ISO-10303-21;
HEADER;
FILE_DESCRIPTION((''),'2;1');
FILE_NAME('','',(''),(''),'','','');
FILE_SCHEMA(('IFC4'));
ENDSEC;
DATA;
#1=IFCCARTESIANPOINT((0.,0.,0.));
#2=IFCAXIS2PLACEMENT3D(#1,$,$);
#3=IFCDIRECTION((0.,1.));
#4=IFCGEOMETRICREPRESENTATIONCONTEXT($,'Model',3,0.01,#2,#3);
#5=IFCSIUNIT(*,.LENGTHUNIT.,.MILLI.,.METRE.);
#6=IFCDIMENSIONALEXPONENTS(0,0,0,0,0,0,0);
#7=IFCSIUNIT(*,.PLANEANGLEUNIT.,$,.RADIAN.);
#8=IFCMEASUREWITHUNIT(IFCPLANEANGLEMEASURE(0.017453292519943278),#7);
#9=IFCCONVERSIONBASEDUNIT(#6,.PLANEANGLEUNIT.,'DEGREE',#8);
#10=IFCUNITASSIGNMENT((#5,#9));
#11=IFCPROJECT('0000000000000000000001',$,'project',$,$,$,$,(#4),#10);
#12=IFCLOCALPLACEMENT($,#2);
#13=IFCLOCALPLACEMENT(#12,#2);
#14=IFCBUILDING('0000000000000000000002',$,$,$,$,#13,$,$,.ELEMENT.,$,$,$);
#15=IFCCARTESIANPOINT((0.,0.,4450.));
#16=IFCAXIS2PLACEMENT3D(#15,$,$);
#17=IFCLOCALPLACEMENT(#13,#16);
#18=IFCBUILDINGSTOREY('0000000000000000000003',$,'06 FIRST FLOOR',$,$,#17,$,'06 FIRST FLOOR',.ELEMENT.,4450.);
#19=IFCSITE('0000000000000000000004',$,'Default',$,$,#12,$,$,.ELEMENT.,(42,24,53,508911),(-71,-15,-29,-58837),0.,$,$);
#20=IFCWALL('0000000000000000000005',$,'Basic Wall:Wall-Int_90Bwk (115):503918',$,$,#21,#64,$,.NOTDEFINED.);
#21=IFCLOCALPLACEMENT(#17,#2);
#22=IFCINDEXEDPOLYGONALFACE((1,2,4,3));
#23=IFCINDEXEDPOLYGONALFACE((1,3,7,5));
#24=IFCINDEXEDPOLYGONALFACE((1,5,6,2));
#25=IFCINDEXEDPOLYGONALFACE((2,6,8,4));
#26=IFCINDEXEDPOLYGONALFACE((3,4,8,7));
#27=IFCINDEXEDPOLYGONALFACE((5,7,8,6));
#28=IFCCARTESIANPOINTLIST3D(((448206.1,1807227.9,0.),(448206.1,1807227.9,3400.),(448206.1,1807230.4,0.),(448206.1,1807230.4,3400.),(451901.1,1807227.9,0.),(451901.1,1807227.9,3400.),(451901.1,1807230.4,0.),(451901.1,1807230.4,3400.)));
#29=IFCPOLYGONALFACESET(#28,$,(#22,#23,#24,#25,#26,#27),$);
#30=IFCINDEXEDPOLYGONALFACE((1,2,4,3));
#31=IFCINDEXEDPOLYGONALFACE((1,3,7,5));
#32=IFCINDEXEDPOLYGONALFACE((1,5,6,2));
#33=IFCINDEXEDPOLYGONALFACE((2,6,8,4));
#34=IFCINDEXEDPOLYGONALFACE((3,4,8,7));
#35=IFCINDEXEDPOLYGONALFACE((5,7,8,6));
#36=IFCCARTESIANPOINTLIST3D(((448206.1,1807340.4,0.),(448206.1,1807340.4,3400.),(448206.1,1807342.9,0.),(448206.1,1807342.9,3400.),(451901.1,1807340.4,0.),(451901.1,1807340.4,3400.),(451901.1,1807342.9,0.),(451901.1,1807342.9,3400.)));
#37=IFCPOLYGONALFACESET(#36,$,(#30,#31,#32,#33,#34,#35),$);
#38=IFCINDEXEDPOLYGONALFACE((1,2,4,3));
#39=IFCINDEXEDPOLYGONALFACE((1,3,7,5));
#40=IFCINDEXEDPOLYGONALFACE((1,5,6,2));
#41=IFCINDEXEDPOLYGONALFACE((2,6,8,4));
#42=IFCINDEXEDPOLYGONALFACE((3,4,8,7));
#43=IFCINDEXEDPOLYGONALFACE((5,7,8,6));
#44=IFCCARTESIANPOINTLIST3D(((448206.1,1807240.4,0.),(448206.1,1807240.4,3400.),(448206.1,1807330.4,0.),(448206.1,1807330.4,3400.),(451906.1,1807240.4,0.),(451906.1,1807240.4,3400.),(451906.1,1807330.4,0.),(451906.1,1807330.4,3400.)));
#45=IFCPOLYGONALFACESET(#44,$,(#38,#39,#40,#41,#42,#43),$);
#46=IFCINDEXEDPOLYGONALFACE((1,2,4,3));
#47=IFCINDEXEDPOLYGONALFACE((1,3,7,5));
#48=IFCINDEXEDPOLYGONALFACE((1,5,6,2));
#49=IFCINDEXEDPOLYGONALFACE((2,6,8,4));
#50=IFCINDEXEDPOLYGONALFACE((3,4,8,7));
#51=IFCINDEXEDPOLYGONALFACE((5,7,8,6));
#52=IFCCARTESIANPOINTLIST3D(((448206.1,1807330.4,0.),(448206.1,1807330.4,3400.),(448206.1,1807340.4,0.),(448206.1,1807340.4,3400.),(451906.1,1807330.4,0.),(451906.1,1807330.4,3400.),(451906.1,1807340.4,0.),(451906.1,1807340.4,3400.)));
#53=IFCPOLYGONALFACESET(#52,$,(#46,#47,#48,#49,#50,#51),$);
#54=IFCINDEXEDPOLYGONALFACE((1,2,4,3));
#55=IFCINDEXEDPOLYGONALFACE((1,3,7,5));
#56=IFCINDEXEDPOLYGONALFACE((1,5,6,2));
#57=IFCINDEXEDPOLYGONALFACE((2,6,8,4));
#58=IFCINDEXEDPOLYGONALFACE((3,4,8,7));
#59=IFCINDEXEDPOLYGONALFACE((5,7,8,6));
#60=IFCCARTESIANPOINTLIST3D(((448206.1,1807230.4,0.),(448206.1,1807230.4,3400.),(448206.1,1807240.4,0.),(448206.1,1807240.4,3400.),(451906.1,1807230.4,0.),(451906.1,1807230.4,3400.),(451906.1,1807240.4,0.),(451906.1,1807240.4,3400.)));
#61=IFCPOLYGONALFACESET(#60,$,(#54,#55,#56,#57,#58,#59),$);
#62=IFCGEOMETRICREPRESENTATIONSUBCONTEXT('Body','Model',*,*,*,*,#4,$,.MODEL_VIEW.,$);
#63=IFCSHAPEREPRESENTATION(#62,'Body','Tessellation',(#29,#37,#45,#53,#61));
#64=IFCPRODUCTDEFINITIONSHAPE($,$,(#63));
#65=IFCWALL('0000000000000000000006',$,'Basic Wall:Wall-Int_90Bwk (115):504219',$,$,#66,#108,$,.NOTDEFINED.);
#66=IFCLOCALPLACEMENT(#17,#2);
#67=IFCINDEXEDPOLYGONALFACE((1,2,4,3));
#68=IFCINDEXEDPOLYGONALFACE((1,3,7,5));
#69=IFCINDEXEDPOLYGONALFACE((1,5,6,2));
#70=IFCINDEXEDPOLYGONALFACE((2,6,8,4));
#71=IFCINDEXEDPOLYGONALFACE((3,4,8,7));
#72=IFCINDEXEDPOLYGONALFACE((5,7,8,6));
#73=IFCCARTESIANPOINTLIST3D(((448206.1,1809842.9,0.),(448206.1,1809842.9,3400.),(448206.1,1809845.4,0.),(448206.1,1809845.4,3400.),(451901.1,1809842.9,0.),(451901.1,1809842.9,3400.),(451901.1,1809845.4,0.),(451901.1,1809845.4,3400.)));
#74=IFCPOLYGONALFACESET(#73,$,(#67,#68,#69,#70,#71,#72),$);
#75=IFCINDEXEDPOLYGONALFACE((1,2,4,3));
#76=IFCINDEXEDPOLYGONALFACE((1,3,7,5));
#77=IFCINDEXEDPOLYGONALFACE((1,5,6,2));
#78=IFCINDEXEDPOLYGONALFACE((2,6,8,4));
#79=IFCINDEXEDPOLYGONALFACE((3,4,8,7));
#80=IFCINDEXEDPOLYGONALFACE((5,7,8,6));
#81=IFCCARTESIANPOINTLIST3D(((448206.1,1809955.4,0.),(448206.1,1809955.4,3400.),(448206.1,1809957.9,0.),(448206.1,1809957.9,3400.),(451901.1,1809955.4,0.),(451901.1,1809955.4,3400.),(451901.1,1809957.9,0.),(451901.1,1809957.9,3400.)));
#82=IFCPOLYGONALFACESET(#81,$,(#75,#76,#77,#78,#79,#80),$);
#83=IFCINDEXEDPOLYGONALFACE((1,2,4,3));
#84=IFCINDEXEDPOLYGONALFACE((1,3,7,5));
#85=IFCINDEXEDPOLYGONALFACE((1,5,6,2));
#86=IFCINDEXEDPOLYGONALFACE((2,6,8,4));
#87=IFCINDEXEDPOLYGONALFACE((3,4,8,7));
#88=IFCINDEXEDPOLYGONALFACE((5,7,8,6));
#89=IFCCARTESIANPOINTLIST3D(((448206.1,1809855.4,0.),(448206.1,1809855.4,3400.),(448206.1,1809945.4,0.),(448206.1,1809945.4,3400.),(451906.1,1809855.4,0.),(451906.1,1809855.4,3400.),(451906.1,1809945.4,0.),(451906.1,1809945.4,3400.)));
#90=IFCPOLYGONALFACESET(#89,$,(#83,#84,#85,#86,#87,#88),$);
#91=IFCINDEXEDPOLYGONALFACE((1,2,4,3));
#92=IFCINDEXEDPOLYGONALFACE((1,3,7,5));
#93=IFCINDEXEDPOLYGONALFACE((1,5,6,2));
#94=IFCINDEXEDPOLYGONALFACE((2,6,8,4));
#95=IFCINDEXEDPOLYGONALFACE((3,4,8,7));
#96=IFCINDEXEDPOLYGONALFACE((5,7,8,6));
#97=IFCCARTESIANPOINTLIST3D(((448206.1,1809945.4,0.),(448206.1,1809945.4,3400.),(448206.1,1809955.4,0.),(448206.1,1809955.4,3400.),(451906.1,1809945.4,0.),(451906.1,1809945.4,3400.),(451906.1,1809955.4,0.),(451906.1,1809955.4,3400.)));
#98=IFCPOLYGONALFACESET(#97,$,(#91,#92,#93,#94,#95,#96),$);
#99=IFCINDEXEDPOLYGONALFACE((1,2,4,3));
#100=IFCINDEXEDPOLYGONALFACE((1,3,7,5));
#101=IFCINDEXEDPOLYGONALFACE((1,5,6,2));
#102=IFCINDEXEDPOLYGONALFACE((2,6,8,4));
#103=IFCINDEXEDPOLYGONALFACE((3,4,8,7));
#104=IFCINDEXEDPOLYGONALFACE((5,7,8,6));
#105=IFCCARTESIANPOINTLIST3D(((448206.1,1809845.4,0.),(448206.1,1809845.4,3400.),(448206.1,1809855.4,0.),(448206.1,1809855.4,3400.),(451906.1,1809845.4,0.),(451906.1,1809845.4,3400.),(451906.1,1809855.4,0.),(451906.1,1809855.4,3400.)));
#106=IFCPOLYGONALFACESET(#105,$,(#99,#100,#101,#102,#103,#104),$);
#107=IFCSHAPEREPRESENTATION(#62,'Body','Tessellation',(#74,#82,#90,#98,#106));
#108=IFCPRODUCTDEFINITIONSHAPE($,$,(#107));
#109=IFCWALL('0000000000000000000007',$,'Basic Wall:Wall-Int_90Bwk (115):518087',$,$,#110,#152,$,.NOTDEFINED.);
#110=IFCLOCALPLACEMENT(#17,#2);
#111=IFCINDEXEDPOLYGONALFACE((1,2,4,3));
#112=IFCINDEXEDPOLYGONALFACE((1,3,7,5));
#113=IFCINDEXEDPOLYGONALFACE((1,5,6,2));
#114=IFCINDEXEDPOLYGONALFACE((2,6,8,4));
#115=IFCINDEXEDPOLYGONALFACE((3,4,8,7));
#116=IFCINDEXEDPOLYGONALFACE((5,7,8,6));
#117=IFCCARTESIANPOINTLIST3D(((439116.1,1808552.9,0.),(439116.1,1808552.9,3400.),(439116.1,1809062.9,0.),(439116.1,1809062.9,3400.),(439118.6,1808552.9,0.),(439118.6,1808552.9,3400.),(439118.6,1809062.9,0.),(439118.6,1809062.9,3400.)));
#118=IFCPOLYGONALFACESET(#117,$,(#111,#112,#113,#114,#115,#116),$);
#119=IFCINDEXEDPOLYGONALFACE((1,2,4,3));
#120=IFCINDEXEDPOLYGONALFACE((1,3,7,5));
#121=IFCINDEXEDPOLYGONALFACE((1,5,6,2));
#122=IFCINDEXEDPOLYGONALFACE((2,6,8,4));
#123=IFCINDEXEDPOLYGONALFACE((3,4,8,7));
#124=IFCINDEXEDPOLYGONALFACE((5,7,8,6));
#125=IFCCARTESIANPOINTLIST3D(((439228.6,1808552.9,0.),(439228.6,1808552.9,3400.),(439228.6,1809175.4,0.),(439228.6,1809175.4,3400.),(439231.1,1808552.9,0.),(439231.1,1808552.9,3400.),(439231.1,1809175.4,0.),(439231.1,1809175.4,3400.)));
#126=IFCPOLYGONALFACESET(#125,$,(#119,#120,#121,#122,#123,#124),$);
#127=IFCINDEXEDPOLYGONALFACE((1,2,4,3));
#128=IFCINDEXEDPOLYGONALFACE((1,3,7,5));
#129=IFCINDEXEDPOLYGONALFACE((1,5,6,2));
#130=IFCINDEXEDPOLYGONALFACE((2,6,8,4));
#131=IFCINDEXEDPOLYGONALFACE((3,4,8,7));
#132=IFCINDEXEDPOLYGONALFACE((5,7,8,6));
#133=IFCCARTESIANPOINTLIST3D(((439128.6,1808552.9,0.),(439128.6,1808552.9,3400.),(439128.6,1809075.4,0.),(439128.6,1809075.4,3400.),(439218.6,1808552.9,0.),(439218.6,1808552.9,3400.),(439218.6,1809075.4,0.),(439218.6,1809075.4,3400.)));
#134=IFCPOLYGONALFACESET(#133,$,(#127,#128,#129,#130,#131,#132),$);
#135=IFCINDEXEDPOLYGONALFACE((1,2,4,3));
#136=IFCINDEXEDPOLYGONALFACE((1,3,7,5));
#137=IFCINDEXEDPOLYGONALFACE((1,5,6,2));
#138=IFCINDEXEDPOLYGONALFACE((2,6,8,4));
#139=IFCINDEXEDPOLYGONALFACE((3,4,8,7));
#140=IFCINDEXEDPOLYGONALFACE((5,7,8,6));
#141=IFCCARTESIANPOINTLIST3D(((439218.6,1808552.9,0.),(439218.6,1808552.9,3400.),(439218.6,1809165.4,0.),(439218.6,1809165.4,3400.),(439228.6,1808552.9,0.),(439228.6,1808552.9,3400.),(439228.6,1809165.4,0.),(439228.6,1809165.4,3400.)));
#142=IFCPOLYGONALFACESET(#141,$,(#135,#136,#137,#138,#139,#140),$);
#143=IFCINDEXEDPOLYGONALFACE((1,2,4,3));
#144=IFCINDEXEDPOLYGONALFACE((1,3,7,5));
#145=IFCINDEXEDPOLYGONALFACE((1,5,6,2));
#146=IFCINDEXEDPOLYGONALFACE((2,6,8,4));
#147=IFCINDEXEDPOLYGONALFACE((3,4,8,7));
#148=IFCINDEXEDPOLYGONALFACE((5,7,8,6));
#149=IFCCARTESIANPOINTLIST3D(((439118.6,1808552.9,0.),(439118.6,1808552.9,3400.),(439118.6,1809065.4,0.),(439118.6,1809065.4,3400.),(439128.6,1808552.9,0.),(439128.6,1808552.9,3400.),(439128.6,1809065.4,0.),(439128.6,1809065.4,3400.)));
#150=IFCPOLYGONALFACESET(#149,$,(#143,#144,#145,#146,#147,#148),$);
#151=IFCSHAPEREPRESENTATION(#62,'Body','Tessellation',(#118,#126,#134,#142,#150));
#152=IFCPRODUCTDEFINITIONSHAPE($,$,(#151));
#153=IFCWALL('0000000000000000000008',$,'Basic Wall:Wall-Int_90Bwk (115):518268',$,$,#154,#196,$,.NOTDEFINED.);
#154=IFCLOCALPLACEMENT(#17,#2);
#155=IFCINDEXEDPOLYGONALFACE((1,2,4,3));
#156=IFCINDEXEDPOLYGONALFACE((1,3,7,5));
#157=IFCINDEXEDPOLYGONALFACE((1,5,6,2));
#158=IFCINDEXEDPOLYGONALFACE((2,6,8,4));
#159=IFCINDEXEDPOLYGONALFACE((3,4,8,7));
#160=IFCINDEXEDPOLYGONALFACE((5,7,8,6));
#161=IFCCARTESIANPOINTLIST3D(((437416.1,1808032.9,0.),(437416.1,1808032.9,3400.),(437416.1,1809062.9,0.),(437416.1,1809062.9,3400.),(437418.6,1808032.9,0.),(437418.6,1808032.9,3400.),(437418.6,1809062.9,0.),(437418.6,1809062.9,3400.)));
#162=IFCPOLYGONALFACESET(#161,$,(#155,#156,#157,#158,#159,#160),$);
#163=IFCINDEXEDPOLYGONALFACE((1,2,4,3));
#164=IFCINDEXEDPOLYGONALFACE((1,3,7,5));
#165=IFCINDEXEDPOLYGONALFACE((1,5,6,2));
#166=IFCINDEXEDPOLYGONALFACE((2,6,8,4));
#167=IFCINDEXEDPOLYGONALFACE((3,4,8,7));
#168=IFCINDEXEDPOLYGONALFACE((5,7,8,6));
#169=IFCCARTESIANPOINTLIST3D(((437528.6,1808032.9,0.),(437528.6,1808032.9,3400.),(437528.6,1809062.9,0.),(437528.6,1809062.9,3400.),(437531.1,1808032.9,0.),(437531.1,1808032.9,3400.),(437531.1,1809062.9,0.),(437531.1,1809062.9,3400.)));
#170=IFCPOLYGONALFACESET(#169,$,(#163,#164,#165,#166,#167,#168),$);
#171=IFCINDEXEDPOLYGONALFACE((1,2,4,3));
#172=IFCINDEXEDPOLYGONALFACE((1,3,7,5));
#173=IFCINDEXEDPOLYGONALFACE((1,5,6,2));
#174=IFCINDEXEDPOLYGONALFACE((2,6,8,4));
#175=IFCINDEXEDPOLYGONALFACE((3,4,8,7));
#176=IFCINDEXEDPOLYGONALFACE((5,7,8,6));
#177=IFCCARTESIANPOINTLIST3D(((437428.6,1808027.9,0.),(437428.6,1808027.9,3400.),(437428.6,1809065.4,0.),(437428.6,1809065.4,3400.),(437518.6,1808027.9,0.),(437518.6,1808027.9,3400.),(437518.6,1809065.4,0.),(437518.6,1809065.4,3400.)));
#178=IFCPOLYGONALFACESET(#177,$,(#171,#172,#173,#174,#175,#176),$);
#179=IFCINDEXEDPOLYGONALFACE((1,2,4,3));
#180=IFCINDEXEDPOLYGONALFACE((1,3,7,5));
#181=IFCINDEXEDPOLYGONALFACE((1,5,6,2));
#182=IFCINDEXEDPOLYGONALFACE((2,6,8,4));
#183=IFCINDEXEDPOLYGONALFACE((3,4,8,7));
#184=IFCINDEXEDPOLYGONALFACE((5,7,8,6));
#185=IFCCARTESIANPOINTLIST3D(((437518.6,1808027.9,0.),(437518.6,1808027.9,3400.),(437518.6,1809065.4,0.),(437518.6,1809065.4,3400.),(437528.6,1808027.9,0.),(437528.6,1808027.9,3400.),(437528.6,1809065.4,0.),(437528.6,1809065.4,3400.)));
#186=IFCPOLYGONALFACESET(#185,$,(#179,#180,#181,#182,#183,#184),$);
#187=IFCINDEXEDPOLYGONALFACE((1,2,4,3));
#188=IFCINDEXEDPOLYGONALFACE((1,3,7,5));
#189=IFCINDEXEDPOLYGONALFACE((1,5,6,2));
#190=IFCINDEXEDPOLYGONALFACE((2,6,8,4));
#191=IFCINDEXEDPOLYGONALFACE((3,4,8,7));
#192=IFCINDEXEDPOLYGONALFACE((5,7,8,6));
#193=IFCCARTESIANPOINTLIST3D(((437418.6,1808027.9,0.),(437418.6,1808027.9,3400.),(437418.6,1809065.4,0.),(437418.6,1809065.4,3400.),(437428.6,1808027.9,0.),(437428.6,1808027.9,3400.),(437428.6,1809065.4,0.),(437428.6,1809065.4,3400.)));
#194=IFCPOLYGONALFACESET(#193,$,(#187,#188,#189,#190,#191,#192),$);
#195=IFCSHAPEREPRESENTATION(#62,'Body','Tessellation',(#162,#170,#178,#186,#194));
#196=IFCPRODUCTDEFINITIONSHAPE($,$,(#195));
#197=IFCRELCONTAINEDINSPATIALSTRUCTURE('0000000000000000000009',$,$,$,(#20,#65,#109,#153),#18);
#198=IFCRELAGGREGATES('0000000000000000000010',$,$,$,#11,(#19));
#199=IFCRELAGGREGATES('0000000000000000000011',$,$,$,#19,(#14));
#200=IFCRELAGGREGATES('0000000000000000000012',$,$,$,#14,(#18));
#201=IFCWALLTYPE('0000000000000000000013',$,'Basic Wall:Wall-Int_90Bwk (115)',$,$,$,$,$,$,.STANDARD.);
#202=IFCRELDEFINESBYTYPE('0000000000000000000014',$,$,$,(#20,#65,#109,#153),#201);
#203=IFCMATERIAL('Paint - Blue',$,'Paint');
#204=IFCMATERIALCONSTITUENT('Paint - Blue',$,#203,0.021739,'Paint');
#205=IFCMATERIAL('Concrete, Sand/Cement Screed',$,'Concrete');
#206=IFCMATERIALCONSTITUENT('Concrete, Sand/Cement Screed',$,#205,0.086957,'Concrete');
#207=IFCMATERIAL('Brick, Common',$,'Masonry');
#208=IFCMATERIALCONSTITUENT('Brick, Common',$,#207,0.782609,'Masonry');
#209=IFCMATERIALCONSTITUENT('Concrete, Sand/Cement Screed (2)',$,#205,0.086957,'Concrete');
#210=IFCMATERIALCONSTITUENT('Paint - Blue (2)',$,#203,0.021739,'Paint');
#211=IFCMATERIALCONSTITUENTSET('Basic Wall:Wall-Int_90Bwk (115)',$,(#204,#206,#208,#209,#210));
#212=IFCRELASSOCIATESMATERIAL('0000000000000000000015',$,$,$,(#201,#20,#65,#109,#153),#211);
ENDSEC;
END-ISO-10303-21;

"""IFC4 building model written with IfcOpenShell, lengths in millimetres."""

from ifc_helpers import new_model, entity, si_unit, converted_unit, direction, frame, origin, place, context, subcontext, project, spatial, indexed_curve, outline, extrude, material, constituent, constituent_set, type_object, element, save


model = new_model("IFC4")

# Units and contexts
model_context = context("Model", 3, precision=0.01, world=origin(), true_north=direction((0.0, 1.0)))
body_context = subcontext(model_context, "Body", "Model", "MODEL_VIEW")
ifc_project = project(units=[si_unit("LENGTHUNIT", "METRE", prefix="MILLI"), converted_unit("PLANEANGLEUNIT", "DEGREE", entity("IfcPlaneAngleMeasure", 0.017453292519943278), si_unit("PLANEANGLEUNIT", "RADIAN"), dimensions=[0, 0, 0, 0, 0, 0, 0])], contexts=[model_context])

# Site, building, storey
site_placement = place(None, origin())
site = spatial("IfcSite", under=ifc_project, at=site_placement, Name="Default", CompositionType="ELEMENT", RefLatitude=(42, 24, 53, 508911), RefLongitude=(-71, -15, -29, -58837), RefElevation=0.0)
building_placement = place(site_placement, origin())
building = spatial("IfcBuilding", under=site, at=building_placement, CompositionType="ELEMENT")
storey_placement = place(building_placement, frame((0.0, 0.0, 4450.0)))
storey = spatial("IfcBuildingStorey", under=building, at=storey_placement, Name="06 FIRST FLOOR", LongName="06 FIRST FLOOR", CompositionType="ELEMENT", Elevation=4450.0)

# Walls
ifc_material_1 = material(Name="Paint - Blue", Category="Paint")
ifc_constituent_1 = constituent(ifc_material_1, Name="Paint - Blue", Category="Paint", fraction=0.021739)
ifc_material_2 = material(Name="Concrete, Sand/Cement Screed", Category="Concrete")
ifc_constituent_2 = constituent(ifc_material_2, Name="Concrete, Sand/Cement Screed", Category="Concrete", fraction=0.086957)
ifc_material_3 = material(Name="Brick, Common", Category="Masonry")
ifc_constituent_3 = constituent(ifc_material_3, Name="Brick, Common", Category="Masonry", fraction=0.782609)
ifc_constituent_4 = constituent(ifc_material_2, Name="Concrete, Sand/Cement Screed (2)", Category="Concrete", fraction=0.086957)
ifc_constituent_5 = constituent(ifc_material_1, Name="Paint - Blue (2)", Category="Paint", fraction=0.021739)
ifc_constituent_set_1 = constituent_set(constituents=[ifc_constituent_1, ifc_constituent_2, ifc_constituent_3, ifc_constituent_4, ifc_constituent_5], Name="Basic Wall:Wall-Int_90Bwk (115)")
wall_type = type_object("IfcWallType", Name="Basic Wall:Wall-Int_90Bwk (115)", PredefinedType="STANDARD", material=ifc_constituent_set_1)
wall_1_placement = place(storey_placement, frame((448206.1, 1807285.4, 0.0)))
element("IfcWall", 1, at=wall_1_placement, inside=storey, type_object=wall_type, material=ifc_constituent_set_1, Name="Basic Wall:Wall-Int_90Bwk (115):503918", PredefinedType="NOTDEFINED", context=body_context, shape_type="SweptSolid", body=[
    extrude(outline(indexed_curve([(-1.2, -1847.5), (1.3, -1847.5), (1.3, 1847.5), (-1.2, 1847.5), (-1.2, -1847.5)], self_intersect=False)), frame((1847.5, -56.3, 0.0), z_axis=(0.0, 0.0, 1.0), x_axis=(0.0, 1.0, 0.0)), (0.0, 0.0, 1.0), 3400.0),
    extrude(outline(indexed_curve([(-1.2, -1847.5), (1.3, -1847.5), (1.3, 1847.5), (-1.2, 1847.5), (-1.2, -1847.5)], self_intersect=False)), frame((1847.5, 56.3, 0.0), z_axis=(0.0, 0.0, 1.0), x_axis=(0.0, -1.0, 0.0)), (0.0, 0.0, 1.0), 3400.0),
    extrude(outline(indexed_curve([(-1850.0, -45.0), (1850.0, -45.0), (1850.0, 45.0), (-1850.0, 45.0), (-1850.0, -45.0)], self_intersect=False)), frame((1850.0, 0.0, 0.0)), (0.0, 0.0, 1.0), 3400.0),
    extrude(outline(indexed_curve([(-1850.0, -5.0), (1850.0, -5.0), (1850.0, 5.0), (-1850.0, 5.0), (-1850.0, -5.0)], self_intersect=False)), frame((1850.0, 50.0, 0.0)), (0.0, 0.0, 1.0), 3400.0),
    extrude(outline(indexed_curve([(-1850.0, -5.0), (1850.0, -5.0), (1850.0, 5.0), (-1850.0, 5.0), (-1850.0, -5.0)], self_intersect=False)), frame((1850.0, -50.0, 0.0)), (0.0, 0.0, 1.0), 3400.0),
])
wall_2_placement = place(storey_placement, frame((448206.1, 1809900.4, 0.0)))
element("IfcWall", 2, at=wall_2_placement, inside=storey, type_object=wall_type, material=ifc_constituent_set_1, Name="Basic Wall:Wall-Int_90Bwk (115):504219", PredefinedType="NOTDEFINED", context=body_context, shape_type="SweptSolid", body=[
    extrude(outline(indexed_curve([(-1.2, -1847.5), (1.3, -1847.5), (1.3, 1847.5), (-1.2, 1847.5), (-1.2, -1847.5)], self_intersect=False)), frame((1847.5, -56.3, 0.0), z_axis=(0.0, 0.0, 1.0), x_axis=(0.0, 1.0, 0.0)), (0.0, 0.0, 1.0), 3400.0),
    extrude(outline(indexed_curve([(-1.3, -1847.5), (1.3, -1847.5), (1.3, 1847.5), (-1.3, 1847.5), (-1.3, -1847.5)], self_intersect=False)), frame((1847.5, 56.3, 0.0), z_axis=(0.0, 0.0, 1.0), x_axis=(0.0, -1.0, 0.0)), (0.0, 0.0, 1.0), 3400.0),
    extrude(outline(indexed_curve([(-1850.0, -45.0), (1850.0, -45.0), (1850.0, 45.0), (-1850.0, 45.0), (-1850.0, -45.0)], self_intersect=False)), frame((1850.0, 0.0, 0.0)), (0.0, 0.0, 1.0), 3400.0),
    extrude(outline(indexed_curve([(-1850.0, -5.0), (1850.0, -5.0), (1850.0, 5.0), (-1850.0, 5.0), (-1850.0, -5.0)], self_intersect=False)), frame((1850.0, 50.0, 0.0)), (0.0, 0.0, 1.0), 3400.0),
    extrude(outline(indexed_curve([(-1850.0, -5.0), (1850.0, -5.0), (1850.0, 5.0), (-1850.0, 5.0), (-1850.0, -5.0)], self_intersect=False)), frame((1850.0, -50.0, 0.0)), (0.0, 0.0, 1.0), 3400.0),
])
wall_3_placement = place(storey_placement, frame((439173.6, 1809062.9, 0.0), z_axis=(0.0, 0.0, 1.0), x_axis=(0.0, -1.0, 0.0)))
element("IfcWall", 3, at=wall_3_placement, inside=storey, type_object=wall_type, material=ifc_constituent_set_1, Name="Basic Wall:Wall-Int_90Bwk (115):518087", PredefinedType="NOTDEFINED", context=body_context, shape_type="SweptSolid", body=[
    extrude(outline(indexed_curve([(-1.3, -255.0), (1.2, -255.0), (1.2, 255.0), (-1.3, 255.0), (-1.3, -255.0)], self_intersect=False)), frame((255.0, -56.2, 0.0), z_axis=(0.0, 0.0, 1.0), x_axis=(0.0, 1.0, 0.0)), (0.0, 0.0, 1.0), 3400.0),
    extrude(outline(indexed_curve([(-1.3, -311.3), (1.2, -311.3), (1.2, 311.3), (-1.3, 311.3), (-1.3, -311.3)], self_intersect=False)), frame((198.8, 56.2, 0.0), z_axis=(0.0, 0.0, 1.0), x_axis=(0.0, -1.0, 0.0)), (0.0, 0.0, 1.0), 3400.0),
    extrude(outline(indexed_curve([(-261.3, -45.0), (261.3, -45.0), (261.3, 45.0), (-261.3, 45.0), (-261.3, -45.0)], self_intersect=False)), frame((248.8, 0.0, 0.0)), (0.0, 0.0, 1.0), 3400.0),
    extrude(outline(indexed_curve([(-306.3, -5.0), (306.3, -5.0), (306.3, 5.0), (-306.3, 5.0), (-306.3, -5.0)], self_intersect=False)), frame((203.8, 50.0, 0.0)), (0.0, 0.0, 1.0), 3400.0),
    extrude(outline(indexed_curve([(-256.3, -5.0), (256.3, -5.0), (256.3, 5.0), (-256.3, 5.0), (-256.3, -5.0)], self_intersect=False)), frame((253.8, -50.0, 0.0)), (0.0, 0.0, 1.0), 3400.0),
])
wall_4_placement = place(storey_placement, frame((437473.6, 1809062.9, 0.0), z_axis=(0.0, 0.0, 1.0), x_axis=(0.0, -1.0, 0.0)))
element("IfcWall", 4, at=wall_4_placement, inside=storey, type_object=wall_type, material=ifc_constituent_set_1, Name="Basic Wall:Wall-Int_90Bwk (115):518268", PredefinedType="NOTDEFINED", context=body_context, shape_type="SweptSolid", body=[
    extrude(outline(indexed_curve([(-1.3, -515.0), (1.2, -515.0), (1.2, 515.0), (-1.3, 515.0), (-1.3, -515.0)], self_intersect=False)), frame((515.0, -56.2, 0.0), z_axis=(0.0, 0.0, 1.0), x_axis=(0.0, 1.0, 0.0)), (0.0, 0.0, 1.0), 3400.0),
    extrude(outline(indexed_curve([(-1.2, -515.0), (1.3, -515.0), (1.3, 515.0), (-1.2, 515.0), (-1.2, -515.0)], self_intersect=False)), frame((515.0, 56.3, 0.0), z_axis=(0.0, 0.0, 1.0), x_axis=(0.0, -1.0, 0.0)), (0.0, 0.0, 1.0), 3400.0),
    extrude(outline(indexed_curve([(-518.8, -45.0), (518.8, -45.0), (518.8, 45.0), (-518.8, 45.0), (-518.8, -45.0)], self_intersect=False)), frame((516.3, 0.0, 0.0)), (0.0, 0.0, 1.0), 3400.0),
    extrude(outline(indexed_curve([(-518.8, -5.0), (518.8, -5.0), (518.8, 5.0), (-518.8, 5.0), (-518.8, -5.0)], self_intersect=False)), frame((516.3, 50.0, 0.0)), (0.0, 0.0, 1.0), 3400.0),
    extrude(outline(indexed_curve([(-518.8, -5.0), (518.8, -5.0), (518.8, 5.0), (-518.8, 5.0), (-518.8, -5.0)], self_intersect=False)), frame((516.3, -50.0, 0.0)), (0.0, 0.0, 1.0), 3400.0),
])

save(model, "model.ifc")
